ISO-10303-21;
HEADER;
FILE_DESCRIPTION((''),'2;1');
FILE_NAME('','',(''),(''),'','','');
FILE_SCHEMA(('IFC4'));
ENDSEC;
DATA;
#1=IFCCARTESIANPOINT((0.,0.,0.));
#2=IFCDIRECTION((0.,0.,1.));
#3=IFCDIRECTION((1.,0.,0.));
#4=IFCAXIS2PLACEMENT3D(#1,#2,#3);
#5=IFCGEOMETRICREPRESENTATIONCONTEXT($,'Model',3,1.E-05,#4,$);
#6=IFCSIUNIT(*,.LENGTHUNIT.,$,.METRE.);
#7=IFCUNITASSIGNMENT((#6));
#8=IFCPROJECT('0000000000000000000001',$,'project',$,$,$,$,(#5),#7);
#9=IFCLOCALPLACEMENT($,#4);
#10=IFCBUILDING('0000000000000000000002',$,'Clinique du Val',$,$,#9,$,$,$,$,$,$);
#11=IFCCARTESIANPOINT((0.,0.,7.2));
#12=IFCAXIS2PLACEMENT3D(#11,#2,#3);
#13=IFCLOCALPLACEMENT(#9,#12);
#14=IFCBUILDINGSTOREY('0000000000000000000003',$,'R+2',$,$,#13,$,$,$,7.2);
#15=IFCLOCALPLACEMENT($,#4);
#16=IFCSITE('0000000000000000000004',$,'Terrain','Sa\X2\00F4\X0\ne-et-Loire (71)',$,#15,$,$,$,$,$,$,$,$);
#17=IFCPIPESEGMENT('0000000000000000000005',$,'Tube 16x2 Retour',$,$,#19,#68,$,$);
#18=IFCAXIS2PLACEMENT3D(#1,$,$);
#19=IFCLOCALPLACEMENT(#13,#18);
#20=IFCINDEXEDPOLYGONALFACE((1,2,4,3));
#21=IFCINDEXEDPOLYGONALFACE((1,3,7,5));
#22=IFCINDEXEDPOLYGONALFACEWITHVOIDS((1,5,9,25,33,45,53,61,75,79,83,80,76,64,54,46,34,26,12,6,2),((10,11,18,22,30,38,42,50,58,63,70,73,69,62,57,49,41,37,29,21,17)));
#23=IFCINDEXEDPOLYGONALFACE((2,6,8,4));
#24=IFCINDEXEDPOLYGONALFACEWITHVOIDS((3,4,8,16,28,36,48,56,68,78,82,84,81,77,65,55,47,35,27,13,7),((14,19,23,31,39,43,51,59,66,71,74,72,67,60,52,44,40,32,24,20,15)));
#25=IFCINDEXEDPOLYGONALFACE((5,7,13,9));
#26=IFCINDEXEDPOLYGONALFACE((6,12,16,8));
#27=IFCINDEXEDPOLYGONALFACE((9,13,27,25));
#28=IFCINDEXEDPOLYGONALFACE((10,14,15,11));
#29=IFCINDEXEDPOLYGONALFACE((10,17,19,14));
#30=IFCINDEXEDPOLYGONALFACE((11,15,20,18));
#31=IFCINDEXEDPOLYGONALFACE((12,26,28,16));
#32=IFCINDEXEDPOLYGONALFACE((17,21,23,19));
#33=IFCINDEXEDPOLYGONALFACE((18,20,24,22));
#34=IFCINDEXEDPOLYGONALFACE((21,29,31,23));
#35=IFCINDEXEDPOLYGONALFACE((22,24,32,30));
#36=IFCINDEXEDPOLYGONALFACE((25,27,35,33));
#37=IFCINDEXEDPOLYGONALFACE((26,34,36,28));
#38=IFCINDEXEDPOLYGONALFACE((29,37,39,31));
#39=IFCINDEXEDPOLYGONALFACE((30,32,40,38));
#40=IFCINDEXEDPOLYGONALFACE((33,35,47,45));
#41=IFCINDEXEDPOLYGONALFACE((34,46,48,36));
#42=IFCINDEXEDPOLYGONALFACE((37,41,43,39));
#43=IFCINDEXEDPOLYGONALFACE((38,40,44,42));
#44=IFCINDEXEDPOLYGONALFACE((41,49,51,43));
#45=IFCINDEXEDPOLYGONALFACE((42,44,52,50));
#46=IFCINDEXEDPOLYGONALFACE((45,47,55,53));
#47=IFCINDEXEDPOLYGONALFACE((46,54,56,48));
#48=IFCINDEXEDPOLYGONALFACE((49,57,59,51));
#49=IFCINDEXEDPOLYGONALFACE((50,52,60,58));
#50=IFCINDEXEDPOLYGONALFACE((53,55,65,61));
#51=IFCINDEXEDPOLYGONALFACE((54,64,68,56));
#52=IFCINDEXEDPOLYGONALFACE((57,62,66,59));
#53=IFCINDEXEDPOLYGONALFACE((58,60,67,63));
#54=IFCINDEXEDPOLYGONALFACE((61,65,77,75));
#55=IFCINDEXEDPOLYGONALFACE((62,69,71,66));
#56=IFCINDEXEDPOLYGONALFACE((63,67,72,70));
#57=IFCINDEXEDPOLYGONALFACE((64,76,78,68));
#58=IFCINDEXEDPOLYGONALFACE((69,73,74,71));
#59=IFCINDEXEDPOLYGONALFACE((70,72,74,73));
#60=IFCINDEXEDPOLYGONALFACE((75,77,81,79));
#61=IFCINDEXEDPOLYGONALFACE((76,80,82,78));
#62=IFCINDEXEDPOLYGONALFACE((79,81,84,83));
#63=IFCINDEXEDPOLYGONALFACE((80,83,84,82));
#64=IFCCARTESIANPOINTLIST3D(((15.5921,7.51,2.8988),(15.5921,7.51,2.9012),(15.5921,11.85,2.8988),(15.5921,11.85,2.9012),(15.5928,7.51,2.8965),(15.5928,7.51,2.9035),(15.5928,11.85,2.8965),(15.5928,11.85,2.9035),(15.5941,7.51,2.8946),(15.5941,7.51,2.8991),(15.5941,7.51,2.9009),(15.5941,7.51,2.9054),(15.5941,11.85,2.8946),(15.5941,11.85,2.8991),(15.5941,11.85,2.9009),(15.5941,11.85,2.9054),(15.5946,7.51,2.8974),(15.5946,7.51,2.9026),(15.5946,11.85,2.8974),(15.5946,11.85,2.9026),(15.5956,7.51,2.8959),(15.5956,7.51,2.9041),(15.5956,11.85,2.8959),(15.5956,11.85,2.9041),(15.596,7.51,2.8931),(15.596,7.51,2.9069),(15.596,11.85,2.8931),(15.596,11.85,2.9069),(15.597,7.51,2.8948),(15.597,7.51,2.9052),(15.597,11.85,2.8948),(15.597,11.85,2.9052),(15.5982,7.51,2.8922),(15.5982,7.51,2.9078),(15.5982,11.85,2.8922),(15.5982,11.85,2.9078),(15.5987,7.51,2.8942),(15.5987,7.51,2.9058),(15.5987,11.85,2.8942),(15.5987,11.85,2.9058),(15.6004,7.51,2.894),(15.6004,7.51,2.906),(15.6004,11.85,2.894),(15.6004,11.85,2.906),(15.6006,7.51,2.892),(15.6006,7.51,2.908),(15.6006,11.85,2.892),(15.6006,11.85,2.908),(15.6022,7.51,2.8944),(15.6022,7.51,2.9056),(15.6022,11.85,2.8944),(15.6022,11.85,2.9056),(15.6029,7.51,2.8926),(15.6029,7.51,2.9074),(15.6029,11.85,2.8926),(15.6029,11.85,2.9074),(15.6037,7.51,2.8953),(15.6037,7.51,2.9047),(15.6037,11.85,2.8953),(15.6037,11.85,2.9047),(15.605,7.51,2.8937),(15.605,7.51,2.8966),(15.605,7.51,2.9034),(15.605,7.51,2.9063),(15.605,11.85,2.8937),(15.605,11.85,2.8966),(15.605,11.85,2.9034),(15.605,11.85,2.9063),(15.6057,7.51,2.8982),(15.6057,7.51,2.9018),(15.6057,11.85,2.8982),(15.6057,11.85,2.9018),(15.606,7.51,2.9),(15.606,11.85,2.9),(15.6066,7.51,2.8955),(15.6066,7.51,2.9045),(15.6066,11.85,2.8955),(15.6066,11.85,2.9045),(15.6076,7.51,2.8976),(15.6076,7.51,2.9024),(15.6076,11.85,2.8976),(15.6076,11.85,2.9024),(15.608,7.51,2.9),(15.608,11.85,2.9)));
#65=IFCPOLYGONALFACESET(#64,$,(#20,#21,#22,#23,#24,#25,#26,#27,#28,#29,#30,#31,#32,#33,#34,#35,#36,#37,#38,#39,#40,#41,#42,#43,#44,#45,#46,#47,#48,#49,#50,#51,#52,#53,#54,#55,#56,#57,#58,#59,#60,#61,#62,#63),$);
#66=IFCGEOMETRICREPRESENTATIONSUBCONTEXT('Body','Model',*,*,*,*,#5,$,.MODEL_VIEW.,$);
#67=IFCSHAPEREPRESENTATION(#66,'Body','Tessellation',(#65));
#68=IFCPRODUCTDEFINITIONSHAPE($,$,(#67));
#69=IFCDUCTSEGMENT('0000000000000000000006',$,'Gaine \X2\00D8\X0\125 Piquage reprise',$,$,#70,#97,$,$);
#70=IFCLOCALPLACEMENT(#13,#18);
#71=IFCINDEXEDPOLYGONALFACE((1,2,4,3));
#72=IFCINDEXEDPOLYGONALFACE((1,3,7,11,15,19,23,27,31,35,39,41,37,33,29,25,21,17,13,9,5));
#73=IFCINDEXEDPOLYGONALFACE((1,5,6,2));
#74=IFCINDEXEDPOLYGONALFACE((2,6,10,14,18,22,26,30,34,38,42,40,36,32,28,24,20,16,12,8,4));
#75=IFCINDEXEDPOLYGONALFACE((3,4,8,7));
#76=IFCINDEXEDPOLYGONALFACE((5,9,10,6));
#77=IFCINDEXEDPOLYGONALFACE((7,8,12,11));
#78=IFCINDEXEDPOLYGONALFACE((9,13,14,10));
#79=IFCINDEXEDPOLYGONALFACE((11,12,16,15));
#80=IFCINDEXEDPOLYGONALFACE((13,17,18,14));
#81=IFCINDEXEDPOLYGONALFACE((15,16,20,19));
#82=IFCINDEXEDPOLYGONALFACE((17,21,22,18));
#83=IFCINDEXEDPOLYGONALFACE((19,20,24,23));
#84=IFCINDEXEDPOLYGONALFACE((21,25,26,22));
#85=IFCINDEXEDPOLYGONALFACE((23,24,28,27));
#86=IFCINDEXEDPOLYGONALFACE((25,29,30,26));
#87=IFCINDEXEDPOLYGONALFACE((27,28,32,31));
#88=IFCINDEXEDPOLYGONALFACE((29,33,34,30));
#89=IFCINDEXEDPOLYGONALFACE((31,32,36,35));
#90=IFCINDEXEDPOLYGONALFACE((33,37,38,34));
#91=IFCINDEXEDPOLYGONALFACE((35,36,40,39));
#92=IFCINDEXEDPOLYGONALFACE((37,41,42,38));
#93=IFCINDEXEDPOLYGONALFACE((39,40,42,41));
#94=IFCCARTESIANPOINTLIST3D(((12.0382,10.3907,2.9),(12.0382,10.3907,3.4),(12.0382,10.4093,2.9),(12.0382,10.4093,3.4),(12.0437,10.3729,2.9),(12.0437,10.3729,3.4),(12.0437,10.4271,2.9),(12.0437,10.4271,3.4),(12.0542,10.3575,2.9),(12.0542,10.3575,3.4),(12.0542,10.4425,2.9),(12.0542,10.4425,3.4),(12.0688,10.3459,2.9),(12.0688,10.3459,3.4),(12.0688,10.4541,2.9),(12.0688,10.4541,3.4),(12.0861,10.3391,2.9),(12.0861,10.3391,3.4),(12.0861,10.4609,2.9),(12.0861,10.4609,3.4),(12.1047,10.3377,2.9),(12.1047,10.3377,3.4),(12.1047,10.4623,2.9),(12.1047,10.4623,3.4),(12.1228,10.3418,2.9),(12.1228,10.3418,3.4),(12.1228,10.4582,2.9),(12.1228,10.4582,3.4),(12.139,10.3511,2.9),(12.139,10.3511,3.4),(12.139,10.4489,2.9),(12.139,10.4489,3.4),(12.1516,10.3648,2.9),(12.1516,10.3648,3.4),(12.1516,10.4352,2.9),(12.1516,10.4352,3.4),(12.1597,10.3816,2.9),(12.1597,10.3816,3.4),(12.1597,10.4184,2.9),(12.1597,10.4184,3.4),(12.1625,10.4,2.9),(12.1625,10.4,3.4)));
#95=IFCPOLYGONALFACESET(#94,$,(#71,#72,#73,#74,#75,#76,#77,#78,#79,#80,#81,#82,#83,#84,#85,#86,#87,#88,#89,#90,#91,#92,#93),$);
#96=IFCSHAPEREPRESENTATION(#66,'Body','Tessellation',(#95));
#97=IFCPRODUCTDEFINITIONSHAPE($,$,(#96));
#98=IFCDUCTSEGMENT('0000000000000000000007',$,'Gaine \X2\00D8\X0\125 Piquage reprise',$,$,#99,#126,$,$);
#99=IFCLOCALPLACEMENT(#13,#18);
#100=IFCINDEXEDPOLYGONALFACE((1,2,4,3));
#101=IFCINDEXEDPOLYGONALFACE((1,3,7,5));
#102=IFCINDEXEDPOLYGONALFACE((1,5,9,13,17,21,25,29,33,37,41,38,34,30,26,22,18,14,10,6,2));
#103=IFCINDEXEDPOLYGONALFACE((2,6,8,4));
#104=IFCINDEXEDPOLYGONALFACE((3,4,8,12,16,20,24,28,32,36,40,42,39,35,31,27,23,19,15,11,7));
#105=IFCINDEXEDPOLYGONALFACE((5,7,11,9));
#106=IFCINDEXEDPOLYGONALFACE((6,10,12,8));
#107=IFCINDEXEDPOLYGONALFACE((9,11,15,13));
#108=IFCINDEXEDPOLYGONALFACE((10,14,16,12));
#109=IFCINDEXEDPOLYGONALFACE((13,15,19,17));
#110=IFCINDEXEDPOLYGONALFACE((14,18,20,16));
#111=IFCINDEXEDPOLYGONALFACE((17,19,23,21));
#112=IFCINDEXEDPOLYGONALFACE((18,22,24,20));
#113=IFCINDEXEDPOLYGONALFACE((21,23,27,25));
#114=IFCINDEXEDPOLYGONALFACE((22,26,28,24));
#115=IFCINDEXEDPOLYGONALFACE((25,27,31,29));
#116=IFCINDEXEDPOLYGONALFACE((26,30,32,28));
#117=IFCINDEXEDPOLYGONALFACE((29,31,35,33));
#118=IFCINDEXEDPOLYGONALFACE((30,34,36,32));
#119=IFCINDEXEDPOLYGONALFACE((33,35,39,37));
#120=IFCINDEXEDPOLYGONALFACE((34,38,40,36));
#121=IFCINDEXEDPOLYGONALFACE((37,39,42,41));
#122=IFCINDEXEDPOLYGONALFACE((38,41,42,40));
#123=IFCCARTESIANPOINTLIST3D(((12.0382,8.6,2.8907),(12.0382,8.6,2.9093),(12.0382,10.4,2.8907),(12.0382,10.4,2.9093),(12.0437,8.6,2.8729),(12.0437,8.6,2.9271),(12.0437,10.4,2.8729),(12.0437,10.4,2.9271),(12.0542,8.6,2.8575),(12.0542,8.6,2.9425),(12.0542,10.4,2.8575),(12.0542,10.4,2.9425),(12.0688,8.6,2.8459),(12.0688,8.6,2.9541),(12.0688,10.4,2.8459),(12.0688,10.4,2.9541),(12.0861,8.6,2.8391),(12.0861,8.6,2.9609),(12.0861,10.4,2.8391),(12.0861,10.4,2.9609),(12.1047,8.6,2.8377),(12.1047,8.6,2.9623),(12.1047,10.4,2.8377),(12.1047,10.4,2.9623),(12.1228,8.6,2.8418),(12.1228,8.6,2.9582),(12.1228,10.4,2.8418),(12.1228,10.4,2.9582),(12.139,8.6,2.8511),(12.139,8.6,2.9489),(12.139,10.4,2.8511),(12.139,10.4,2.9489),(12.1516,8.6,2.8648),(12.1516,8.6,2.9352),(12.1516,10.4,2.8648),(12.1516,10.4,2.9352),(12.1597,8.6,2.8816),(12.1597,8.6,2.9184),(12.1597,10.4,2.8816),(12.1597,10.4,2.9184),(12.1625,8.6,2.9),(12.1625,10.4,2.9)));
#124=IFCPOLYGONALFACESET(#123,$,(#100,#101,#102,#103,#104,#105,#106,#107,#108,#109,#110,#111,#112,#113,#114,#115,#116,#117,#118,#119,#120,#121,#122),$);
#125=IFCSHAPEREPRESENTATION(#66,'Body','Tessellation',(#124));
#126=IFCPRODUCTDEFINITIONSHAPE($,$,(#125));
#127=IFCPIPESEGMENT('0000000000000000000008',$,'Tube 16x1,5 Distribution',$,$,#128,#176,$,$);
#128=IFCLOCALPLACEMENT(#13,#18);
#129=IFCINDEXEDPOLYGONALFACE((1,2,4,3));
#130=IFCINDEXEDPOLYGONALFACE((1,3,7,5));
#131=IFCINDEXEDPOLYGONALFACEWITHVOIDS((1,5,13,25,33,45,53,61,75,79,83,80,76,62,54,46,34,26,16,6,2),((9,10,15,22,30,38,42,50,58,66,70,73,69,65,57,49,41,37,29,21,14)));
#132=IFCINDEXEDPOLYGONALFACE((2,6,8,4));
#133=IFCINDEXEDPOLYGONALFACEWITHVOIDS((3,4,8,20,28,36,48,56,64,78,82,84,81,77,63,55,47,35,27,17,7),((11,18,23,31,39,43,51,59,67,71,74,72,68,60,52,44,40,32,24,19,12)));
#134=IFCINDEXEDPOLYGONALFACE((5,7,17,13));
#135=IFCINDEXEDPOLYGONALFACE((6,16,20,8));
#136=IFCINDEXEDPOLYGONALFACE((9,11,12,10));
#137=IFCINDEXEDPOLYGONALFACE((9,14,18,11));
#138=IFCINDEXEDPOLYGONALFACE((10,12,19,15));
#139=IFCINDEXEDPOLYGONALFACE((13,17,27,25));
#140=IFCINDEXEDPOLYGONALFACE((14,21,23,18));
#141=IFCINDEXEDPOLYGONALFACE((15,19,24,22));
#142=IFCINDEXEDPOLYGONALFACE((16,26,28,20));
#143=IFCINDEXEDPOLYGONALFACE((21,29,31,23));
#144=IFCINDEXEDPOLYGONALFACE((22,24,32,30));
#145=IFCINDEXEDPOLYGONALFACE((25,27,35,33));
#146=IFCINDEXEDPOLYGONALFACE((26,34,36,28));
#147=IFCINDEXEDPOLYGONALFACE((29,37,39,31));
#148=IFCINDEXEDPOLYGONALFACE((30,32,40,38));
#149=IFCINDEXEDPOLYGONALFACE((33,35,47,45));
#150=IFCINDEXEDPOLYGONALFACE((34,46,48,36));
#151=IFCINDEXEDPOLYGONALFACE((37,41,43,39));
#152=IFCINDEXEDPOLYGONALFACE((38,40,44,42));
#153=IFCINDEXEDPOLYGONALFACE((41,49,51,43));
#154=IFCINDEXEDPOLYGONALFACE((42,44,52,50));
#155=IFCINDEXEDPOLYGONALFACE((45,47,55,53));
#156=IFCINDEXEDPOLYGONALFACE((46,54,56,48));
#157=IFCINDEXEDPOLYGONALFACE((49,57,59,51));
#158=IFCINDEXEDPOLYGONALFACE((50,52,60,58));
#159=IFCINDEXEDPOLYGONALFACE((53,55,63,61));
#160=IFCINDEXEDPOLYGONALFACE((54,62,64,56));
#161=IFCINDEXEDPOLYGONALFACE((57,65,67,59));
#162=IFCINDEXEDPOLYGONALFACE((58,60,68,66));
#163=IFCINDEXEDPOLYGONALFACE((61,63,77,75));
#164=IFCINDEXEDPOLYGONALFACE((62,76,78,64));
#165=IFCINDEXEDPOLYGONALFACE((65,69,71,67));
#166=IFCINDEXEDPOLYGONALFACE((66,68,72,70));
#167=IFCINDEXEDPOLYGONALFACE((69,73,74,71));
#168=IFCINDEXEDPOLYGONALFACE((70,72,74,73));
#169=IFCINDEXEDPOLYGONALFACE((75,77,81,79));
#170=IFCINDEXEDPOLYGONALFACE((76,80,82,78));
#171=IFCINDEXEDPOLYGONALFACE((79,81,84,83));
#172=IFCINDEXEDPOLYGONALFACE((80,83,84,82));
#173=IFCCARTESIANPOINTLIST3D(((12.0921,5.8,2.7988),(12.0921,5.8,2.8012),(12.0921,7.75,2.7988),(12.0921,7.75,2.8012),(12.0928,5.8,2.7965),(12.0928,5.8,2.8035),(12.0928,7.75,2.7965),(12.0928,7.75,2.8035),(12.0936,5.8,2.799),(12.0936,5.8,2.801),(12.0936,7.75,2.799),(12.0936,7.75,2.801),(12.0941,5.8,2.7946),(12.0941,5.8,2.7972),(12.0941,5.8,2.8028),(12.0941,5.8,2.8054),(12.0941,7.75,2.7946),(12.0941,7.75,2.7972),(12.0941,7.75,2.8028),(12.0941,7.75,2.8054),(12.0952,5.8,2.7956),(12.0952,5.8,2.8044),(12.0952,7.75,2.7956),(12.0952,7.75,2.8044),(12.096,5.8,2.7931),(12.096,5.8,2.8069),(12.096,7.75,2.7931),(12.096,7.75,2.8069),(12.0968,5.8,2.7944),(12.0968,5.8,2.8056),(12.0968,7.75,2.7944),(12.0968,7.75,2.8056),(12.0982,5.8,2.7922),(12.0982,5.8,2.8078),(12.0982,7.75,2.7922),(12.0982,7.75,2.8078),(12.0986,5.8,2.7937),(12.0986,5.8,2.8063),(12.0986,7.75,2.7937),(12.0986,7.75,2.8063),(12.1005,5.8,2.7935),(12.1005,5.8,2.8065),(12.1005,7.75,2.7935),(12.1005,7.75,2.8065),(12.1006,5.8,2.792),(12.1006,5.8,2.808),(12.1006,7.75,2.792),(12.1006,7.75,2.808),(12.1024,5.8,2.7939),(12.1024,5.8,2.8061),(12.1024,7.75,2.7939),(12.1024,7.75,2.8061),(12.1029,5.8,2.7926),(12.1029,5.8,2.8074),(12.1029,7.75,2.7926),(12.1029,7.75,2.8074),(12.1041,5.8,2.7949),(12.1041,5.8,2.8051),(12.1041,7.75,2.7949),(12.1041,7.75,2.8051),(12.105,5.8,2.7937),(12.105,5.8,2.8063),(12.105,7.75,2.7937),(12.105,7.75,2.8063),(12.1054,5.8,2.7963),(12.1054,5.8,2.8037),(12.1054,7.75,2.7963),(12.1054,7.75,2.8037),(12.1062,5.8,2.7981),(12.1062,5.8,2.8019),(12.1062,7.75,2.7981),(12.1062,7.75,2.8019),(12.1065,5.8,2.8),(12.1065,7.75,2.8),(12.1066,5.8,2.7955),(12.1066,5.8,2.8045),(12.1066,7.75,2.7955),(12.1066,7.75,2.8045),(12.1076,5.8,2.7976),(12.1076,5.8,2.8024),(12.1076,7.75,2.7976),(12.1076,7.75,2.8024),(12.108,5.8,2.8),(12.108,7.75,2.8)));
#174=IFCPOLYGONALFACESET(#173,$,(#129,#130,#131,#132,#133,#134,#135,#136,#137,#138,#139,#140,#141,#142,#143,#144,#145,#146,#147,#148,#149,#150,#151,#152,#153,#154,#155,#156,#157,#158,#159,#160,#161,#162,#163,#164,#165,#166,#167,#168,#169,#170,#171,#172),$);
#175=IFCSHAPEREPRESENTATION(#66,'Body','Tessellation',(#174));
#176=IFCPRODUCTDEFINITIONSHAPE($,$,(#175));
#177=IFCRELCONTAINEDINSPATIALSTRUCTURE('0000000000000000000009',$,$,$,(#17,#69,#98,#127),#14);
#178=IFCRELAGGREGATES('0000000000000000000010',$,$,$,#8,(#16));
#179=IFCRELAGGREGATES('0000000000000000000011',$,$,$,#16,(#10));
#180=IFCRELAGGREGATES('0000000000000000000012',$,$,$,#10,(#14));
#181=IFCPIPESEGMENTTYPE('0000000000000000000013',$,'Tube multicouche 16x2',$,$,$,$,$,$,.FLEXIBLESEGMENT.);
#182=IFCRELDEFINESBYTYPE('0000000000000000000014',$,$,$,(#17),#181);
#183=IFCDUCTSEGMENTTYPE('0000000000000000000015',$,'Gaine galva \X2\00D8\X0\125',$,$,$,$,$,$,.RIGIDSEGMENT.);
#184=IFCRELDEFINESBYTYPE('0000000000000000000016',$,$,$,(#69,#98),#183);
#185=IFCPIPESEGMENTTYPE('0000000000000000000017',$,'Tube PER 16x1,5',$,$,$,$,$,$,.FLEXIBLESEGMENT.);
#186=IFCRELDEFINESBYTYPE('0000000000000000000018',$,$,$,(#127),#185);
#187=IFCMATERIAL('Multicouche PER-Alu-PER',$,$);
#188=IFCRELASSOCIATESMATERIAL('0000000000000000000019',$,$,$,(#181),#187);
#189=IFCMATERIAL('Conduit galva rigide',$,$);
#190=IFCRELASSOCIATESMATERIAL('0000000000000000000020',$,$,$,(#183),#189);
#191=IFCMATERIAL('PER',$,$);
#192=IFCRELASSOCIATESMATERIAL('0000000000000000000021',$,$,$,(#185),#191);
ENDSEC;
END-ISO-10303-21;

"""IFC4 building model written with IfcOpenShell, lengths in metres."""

from ifc_helpers import new_model, si_unit, frame, origin_with_axes, place, context, subcontext, project, spatial, circle, hollow_circle, extrude, material, type_object, element, save


model = new_model("IFC4")

# Units and contexts
model_context = context("Model", 3, precision=1e-05, world=origin_with_axes())
body_context = subcontext(model_context, "Body", "Model", "MODEL_VIEW")
ifc_project = project(units=[si_unit("LENGTHUNIT", "METRE")], contexts=[model_context])

# Site, building, storey
site_placement = place(None, origin_with_axes())
site = spatial("IfcSite", under=ifc_project, at=site_placement, Name="Terrain", Description="Saône-et-Loire (71)")
building_placement = place(None, origin_with_axes())
building = spatial("IfcBuilding", under=site, at=building_placement, Name="Clinique du Val")
storey_placement = place(building_placement, frame((0.0, 0.0, 7.2), z_axis=(0.0, 0.0, 1.0), x_axis=(1.0, 0.0, 0.0)))
storey = spatial("IfcBuildingStorey", under=building, at=storey_placement, Name="R+2", Elevation=7.2)

# Pipe segment
ifc_material_1 = material(Name="Multicouche PER-Alu-PER")
pipe_segment_type_1 = type_object("IfcPipeSegmentType", Name="Tube multicouche 16x2", PredefinedType="FLEXIBLESEGMENT", material=ifc_material_1)
pipe_segment_1_placement = place(storey_placement, frame((15.6, 7.51, 2.9), z_axis=(0.0, 1.0, 0.0), x_axis=(1.0, 0.0, 0.0)))
element("IfcPipeSegment", 1, at=pipe_segment_1_placement, inside=storey, type_object=pipe_segment_type_1, Name="Tube 16x2 Retour", context=body_context, shape_type="SweptSolid", body=[
    extrude(hollow_circle(Radius=0.008, WallThickness=0.002), origin_with_axes(), (0.0, 0.0, 1.0), 4.34),
])

# Duct segments
ifc_material_2 = material(Name="Conduit galva rigide")
duct_segment_type = type_object("IfcDuctSegmentType", Name="Gaine galva Ø125", PredefinedType="RIGIDSEGMENT", material=ifc_material_2)
duct_segment_1_placement = place(storey_placement, frame((12.1, 10.4, 3.4), z_axis=(0.0, 0.0, -1.0), x_axis=(1.0, 0.0, 0.0)))
element("IfcDuctSegment", 2, at=duct_segment_1_placement, inside=storey, type_object=duct_segment_type, Name="Gaine Ø125 Piquage reprise", context=body_context, shape_type="SweptSolid", body=[
    extrude(circle(Radius=0.0625), origin_with_axes(), (0.0, 0.0, 1.0), 0.5),
])
duct_segment_2_placement = place(storey_placement, frame((12.1, 10.4, 2.9), z_axis=(0.0, -1.0, 0.0), x_axis=(1.0, 0.0, 0.0)))
element("IfcDuctSegment", 3, at=duct_segment_2_placement, inside=storey, type_object=duct_segment_type, Name="Gaine Ø125 Piquage reprise", context=body_context, shape_type="SweptSolid", body=[
    extrude(circle(Radius=0.0625), origin_with_axes(), (0.0, 0.0, 1.0), 1.8),
])

# Pipe segment
ifc_material_3 = material(Name="PER")
pipe_segment_type_2 = type_object("IfcPipeSegmentType", Name="Tube PER 16x1,5", PredefinedType="FLEXIBLESEGMENT", material=ifc_material_3)
pipe_segment_2_placement = place(storey_placement, frame((12.1, 7.75, 2.8), z_axis=(0.0, -1.0, 0.0), x_axis=(1.0, 0.0, 0.0)))
element("IfcPipeSegment", 4, at=pipe_segment_2_placement, inside=storey, type_object=pipe_segment_type_2, Name="Tube 16x1,5 Distribution", context=body_context, shape_type="SweptSolid", body=[
    extrude(hollow_circle(Radius=0.008, WallThickness=0.0015), origin_with_axes(), (0.0, 0.0, 1.0), 1.95),
])

save(model, "model.ifc")
